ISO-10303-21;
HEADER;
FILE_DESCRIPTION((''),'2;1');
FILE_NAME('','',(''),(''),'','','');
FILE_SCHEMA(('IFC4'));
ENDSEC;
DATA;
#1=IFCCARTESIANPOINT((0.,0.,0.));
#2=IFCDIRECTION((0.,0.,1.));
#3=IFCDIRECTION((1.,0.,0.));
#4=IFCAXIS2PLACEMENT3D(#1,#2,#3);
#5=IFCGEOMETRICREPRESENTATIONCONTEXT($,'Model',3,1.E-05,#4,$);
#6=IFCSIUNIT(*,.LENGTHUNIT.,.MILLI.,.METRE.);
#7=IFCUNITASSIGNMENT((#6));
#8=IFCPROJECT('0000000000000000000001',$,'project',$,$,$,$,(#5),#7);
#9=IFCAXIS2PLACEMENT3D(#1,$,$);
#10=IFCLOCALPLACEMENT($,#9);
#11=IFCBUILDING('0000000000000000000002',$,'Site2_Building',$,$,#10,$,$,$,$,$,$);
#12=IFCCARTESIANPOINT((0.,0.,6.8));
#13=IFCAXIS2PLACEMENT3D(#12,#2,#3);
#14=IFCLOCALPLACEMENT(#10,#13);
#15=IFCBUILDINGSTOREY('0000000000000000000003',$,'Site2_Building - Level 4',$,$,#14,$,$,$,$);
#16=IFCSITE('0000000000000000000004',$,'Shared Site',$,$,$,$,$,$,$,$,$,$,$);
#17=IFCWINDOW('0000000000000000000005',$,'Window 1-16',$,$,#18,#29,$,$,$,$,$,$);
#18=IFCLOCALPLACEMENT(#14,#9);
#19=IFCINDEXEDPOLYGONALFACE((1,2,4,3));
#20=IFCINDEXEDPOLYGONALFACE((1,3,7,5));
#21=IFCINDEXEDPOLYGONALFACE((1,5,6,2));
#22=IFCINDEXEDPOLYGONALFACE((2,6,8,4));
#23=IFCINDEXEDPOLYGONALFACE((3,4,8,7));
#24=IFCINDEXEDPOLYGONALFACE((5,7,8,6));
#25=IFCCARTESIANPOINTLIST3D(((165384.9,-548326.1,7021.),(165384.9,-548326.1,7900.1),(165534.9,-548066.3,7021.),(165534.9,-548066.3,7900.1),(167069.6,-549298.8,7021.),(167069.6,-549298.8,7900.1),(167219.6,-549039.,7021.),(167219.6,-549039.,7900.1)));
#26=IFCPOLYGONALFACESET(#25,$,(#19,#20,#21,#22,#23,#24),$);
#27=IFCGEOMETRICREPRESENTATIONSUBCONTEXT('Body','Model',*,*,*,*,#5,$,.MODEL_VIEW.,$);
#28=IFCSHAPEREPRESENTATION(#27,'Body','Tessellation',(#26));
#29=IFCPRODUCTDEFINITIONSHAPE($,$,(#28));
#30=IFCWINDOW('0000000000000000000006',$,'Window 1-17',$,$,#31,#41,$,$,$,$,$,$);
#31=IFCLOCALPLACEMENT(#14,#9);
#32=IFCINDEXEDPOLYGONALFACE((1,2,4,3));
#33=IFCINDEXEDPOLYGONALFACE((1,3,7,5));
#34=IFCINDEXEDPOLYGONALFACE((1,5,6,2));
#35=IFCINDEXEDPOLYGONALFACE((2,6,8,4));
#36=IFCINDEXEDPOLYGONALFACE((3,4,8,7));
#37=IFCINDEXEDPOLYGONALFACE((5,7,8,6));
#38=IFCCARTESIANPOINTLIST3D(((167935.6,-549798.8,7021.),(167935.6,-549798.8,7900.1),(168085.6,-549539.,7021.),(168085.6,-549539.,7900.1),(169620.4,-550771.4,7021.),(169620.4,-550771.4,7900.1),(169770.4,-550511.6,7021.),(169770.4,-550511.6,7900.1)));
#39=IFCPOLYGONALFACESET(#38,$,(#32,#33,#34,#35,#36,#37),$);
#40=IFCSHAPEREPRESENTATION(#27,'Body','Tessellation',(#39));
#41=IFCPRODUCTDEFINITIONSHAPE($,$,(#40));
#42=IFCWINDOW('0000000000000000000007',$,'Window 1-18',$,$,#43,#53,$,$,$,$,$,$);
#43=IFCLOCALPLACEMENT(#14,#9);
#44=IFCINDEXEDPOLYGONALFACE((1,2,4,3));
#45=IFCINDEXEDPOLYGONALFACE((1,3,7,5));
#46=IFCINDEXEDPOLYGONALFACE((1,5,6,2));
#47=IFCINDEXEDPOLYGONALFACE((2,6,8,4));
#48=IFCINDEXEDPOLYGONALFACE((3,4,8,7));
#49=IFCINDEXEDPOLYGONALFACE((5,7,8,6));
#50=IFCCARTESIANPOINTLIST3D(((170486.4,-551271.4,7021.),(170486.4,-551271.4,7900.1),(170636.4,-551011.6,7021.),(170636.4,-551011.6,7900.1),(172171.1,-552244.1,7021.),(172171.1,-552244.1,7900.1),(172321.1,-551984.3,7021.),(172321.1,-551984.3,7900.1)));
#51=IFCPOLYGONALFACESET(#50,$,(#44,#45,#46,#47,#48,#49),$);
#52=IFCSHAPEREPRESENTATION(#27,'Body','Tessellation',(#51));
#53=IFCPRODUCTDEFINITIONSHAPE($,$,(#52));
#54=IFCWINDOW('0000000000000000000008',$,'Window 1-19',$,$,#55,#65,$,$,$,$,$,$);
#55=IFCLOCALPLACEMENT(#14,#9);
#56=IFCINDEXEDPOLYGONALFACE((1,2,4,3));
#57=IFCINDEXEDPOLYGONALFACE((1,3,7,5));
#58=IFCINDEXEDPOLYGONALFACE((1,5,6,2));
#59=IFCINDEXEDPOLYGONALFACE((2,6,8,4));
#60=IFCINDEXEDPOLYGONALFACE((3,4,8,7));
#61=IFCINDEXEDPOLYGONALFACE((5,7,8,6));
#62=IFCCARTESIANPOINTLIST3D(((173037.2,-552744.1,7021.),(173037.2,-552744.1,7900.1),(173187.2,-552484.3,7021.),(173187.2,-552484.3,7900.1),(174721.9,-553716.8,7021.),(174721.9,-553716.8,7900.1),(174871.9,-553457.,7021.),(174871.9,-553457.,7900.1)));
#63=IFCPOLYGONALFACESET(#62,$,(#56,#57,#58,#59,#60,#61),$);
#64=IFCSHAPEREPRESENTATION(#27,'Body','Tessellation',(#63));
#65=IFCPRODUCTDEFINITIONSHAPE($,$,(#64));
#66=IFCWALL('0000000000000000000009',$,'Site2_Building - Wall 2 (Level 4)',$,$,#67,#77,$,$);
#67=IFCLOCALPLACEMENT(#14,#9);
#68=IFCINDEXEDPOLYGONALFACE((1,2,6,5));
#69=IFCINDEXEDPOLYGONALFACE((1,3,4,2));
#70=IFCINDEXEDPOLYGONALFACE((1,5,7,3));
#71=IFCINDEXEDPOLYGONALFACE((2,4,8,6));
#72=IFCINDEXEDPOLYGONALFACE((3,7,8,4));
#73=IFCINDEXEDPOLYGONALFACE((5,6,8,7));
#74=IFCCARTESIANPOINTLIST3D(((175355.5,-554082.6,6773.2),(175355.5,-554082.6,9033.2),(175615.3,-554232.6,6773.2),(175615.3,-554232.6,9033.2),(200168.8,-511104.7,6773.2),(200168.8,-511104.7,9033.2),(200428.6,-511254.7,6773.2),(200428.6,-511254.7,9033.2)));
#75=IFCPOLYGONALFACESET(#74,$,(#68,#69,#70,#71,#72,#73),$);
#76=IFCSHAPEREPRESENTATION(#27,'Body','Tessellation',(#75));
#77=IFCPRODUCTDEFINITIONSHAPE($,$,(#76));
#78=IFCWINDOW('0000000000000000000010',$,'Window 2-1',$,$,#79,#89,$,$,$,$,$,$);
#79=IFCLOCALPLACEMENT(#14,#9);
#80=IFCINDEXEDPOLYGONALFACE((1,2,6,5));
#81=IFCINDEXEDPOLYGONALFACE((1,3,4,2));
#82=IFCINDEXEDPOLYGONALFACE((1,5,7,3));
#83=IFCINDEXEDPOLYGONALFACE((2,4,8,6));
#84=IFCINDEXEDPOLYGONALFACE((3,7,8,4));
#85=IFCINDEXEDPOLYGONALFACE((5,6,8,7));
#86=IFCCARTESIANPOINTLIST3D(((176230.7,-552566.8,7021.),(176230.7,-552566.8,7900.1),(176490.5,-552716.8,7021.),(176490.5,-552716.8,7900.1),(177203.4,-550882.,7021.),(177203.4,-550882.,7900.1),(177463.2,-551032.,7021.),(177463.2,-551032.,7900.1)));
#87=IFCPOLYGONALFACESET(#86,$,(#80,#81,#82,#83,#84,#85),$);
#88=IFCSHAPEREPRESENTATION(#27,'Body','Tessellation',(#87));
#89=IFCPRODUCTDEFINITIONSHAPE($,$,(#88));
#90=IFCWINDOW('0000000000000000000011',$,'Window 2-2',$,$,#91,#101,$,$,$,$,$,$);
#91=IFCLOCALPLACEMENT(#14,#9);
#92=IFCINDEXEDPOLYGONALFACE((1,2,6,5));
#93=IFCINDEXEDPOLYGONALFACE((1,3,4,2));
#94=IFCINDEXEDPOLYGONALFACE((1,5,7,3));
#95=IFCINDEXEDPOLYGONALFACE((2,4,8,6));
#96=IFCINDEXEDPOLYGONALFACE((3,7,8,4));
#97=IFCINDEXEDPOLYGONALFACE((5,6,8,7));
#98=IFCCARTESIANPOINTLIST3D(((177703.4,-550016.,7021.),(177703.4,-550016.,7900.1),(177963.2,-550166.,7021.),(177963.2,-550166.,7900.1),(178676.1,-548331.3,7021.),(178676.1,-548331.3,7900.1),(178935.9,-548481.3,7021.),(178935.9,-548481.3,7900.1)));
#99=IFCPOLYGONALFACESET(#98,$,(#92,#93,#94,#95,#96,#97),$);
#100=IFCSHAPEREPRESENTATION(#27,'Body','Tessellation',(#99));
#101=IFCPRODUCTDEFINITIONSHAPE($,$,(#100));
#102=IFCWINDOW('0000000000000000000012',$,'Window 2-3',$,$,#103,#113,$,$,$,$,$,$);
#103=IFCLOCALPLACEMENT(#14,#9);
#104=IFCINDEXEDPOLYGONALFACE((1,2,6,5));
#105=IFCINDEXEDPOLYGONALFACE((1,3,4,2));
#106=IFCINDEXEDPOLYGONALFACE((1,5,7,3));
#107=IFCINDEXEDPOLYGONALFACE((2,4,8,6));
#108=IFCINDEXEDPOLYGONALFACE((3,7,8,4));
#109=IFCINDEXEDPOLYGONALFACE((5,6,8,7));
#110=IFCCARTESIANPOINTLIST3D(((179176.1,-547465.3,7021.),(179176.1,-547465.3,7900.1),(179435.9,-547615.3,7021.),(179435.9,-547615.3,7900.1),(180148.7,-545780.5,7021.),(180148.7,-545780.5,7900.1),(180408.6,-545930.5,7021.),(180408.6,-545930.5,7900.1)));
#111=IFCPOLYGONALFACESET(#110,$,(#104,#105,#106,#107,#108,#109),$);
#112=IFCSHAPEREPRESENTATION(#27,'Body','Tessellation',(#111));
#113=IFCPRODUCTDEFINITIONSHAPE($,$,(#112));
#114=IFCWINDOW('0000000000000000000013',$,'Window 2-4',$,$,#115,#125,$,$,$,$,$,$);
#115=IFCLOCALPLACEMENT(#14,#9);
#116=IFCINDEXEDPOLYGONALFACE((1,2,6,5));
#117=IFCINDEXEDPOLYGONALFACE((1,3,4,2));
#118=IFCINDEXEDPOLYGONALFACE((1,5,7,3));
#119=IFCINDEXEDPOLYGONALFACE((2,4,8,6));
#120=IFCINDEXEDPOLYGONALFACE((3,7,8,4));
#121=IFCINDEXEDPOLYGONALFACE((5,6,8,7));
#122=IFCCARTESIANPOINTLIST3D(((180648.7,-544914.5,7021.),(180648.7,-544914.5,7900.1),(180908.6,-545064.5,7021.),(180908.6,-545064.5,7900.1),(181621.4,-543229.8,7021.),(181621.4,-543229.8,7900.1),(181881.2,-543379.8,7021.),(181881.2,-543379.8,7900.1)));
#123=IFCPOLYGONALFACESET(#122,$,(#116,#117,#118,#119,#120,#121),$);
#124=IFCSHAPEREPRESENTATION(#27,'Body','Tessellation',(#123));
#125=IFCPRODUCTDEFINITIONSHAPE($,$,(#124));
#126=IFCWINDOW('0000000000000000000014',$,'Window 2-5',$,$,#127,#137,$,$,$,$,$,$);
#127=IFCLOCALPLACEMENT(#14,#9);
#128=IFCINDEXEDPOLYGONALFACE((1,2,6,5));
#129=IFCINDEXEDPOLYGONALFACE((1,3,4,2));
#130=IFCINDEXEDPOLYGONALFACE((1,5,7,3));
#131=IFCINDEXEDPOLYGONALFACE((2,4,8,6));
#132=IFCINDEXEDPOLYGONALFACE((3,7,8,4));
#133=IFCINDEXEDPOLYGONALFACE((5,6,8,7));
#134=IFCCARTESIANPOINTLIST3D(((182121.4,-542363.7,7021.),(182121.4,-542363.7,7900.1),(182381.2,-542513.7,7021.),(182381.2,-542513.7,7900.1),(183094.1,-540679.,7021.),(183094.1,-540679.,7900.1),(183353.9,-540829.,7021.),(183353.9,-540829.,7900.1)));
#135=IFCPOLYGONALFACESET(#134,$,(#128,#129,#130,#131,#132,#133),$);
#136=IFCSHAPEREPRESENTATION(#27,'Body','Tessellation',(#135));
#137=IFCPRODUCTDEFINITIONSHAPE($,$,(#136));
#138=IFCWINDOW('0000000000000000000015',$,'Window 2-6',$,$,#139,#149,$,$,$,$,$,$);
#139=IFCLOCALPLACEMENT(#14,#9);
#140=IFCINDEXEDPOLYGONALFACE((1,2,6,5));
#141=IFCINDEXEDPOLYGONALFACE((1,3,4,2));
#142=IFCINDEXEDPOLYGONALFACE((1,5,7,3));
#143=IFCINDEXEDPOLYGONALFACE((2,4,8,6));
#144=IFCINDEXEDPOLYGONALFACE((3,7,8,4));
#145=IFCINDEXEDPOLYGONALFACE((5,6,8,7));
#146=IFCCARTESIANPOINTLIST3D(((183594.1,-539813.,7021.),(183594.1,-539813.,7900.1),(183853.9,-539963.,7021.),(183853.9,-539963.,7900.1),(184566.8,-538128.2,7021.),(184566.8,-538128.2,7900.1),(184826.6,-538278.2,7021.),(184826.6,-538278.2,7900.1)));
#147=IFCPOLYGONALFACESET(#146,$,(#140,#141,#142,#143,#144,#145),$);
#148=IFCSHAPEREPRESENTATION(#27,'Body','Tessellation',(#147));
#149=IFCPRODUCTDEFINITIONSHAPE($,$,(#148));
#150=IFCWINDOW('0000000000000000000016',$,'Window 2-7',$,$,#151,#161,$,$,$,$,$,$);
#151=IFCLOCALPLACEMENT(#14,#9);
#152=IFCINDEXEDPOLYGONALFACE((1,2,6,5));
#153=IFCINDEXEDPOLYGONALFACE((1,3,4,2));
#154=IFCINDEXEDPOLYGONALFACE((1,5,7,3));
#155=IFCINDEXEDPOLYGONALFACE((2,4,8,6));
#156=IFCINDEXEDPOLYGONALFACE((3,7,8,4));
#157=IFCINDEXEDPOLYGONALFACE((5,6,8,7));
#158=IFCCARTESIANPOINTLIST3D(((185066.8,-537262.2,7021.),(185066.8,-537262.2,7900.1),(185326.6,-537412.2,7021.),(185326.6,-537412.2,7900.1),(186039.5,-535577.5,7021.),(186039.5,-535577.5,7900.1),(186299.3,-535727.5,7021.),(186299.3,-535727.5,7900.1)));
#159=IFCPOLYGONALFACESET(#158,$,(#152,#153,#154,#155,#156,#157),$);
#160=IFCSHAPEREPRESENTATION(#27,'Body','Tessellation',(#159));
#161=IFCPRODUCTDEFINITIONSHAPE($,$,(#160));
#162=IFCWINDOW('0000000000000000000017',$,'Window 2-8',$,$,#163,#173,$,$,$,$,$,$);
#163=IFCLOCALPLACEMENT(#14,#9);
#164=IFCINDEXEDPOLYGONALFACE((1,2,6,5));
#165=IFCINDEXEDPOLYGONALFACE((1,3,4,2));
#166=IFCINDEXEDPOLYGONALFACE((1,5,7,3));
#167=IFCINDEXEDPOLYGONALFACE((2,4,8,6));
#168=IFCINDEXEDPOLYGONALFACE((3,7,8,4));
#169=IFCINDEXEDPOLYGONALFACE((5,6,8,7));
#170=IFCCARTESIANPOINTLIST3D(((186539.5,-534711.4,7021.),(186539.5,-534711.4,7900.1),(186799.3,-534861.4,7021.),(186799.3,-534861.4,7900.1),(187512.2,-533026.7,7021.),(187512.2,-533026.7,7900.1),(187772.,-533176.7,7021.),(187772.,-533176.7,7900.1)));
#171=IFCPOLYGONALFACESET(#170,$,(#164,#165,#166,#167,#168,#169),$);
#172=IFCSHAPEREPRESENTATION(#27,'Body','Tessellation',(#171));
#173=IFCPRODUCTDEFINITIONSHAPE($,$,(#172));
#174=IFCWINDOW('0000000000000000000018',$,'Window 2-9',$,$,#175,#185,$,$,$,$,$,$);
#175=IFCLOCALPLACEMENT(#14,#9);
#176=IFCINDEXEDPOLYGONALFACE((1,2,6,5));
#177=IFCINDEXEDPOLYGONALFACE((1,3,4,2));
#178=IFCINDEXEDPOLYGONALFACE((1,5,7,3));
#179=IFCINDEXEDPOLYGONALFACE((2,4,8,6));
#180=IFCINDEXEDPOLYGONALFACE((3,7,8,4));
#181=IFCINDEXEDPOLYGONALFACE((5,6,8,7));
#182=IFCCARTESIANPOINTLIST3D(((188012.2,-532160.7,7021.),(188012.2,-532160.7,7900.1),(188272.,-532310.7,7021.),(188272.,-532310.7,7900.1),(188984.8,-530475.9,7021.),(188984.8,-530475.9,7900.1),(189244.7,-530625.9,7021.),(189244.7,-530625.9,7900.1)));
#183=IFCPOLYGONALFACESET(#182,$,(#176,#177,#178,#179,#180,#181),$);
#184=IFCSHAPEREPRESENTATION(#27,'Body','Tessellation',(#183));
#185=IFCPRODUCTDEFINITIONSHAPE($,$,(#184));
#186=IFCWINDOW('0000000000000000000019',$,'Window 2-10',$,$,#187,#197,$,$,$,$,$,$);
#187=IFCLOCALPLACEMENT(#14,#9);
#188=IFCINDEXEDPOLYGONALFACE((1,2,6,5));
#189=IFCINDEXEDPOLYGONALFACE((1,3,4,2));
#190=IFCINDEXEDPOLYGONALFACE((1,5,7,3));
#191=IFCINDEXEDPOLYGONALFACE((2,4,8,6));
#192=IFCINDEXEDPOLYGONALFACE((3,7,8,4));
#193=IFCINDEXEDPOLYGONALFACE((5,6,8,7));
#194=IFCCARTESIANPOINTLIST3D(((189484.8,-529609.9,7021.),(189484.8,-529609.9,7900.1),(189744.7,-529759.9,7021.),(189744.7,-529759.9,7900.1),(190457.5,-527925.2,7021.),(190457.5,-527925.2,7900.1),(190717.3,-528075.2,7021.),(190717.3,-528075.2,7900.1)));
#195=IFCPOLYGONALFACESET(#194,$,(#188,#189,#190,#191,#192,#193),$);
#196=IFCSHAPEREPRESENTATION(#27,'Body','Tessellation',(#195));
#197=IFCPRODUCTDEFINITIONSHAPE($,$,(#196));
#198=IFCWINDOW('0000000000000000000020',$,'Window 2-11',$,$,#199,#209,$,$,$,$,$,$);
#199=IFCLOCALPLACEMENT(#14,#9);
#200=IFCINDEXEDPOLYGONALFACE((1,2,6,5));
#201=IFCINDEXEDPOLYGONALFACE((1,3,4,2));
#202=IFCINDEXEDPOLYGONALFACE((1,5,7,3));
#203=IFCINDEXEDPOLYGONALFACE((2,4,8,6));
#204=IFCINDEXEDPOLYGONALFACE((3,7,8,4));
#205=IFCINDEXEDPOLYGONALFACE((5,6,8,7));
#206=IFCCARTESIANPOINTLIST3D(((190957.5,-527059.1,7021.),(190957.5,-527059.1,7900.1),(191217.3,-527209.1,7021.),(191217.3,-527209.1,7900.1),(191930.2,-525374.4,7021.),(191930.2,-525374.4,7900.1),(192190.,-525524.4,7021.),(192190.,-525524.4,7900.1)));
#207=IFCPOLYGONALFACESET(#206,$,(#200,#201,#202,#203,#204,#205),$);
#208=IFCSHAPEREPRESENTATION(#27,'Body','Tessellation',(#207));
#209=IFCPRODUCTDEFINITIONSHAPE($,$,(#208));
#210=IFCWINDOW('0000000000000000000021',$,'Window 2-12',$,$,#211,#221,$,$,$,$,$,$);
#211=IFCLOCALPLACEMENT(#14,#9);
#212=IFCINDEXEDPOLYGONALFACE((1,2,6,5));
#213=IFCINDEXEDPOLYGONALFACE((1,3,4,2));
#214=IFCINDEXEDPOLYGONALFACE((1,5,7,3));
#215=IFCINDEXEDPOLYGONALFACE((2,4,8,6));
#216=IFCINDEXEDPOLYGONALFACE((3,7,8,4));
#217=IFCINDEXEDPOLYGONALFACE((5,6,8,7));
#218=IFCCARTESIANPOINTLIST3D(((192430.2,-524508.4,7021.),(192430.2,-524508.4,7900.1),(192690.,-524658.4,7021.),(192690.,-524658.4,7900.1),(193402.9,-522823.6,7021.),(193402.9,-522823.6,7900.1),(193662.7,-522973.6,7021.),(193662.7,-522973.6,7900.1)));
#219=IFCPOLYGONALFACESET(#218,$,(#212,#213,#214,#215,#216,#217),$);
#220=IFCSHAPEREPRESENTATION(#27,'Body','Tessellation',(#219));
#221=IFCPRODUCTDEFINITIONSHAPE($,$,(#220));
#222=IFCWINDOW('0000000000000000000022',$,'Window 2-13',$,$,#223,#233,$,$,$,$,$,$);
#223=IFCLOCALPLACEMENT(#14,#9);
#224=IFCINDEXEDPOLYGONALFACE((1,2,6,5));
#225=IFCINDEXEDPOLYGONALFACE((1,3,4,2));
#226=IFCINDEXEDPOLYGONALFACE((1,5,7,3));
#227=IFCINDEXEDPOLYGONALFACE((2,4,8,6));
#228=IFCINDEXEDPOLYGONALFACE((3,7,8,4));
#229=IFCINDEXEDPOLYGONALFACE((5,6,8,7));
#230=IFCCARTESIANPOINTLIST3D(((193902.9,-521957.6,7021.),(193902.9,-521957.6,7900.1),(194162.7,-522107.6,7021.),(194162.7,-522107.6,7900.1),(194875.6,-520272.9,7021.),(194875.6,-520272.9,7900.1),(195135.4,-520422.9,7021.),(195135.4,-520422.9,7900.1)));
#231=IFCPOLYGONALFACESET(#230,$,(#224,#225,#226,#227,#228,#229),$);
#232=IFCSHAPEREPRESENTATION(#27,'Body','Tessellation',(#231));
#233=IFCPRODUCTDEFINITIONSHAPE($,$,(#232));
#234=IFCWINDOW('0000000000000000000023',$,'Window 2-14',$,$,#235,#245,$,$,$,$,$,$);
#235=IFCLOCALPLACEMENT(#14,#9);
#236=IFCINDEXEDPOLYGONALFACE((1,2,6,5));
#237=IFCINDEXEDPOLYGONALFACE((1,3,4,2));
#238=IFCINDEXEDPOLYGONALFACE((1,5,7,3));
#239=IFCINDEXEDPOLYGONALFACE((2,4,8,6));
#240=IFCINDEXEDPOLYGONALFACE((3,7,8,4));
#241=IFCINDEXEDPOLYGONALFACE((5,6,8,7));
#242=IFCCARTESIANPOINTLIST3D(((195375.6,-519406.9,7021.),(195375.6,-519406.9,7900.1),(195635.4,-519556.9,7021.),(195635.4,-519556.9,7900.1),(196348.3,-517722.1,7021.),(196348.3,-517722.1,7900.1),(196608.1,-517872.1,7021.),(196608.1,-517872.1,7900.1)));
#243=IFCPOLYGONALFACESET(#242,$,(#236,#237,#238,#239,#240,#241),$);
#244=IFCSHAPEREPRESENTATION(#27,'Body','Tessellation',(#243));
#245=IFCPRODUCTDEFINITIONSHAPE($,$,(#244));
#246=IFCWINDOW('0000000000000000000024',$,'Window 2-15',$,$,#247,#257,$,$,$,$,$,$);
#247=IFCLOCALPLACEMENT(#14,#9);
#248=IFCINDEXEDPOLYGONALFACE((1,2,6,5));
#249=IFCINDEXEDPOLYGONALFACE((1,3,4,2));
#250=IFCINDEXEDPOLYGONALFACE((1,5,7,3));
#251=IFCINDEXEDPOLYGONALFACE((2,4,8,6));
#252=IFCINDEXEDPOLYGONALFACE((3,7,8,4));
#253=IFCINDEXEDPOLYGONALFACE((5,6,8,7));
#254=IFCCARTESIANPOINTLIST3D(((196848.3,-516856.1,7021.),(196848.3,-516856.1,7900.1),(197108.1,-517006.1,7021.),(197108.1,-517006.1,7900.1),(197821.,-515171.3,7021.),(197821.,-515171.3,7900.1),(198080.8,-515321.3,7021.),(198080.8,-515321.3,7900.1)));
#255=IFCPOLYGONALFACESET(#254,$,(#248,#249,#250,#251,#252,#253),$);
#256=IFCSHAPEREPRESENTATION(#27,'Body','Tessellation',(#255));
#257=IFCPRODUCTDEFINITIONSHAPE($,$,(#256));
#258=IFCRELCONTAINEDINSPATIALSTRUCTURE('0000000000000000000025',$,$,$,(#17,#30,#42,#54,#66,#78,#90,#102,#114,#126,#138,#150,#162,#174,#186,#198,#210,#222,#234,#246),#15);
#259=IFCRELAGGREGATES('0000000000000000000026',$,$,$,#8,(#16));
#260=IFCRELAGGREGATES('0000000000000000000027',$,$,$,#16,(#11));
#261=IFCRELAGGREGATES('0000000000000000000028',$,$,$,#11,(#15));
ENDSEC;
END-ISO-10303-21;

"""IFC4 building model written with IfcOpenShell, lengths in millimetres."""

from ifc_helpers import new_model, si_unit, frame, origin, origin_with_axes, place, context, subcontext, project, spatial, indexed_curve, outline, extrude, element, save


model = new_model("IFC4")

# Units and contexts
model_context = context("Model", 3, precision=1e-05, world=origin_with_axes())
body_context = subcontext(model_context, "Body", "Model", "MODEL_VIEW")
ifc_project = project(units=[si_unit("LENGTHUNIT", "METRE", prefix="MILLI")], contexts=[model_context])

# Site, building, storey
site = spatial("IfcSite", under=ifc_project, Name="Shared Site")
building_placement = place(None, origin())
building = spatial("IfcBuilding", under=site, at=building_placement, Name="Site2_Building")
storey_placement = place(building_placement, frame((0.0, 0.0, 6.8), z_axis=(0.0, 0.0, 1.0), x_axis=(1.0, 0.0, 0.0)))
storey = spatial("IfcBuildingStorey", under=building, at=storey_placement, Name="Site2_Building - Level 4")

# Windows
for number, where, z_axis, x_axis, name in (
    (1, (165384.9, -548326.1, 7021.0), (0.0, 0.0, 1.0), (0.866025, -0.5, 0.0), "Window 1-16"),
    (2, (167935.6, -549798.8, 7021.0), (0.0, 0.0, 1.0), (0.866025, -0.5, 0.0), "Window 1-17"),
    (3, (170486.4, -551271.4, 7021.0), (0.0, 0.0, 1.0), (0.866025, -0.5, 0.0), "Window 1-18"),
    (4, (173037.2, -552744.1, 7021.0), (0.0, 0.0, 1.0), (0.866025, -0.5, 0.0), "Window 1-19"),
):
    element("IfcWindow", number, at=place(storey_placement, frame(where, z_axis=z_axis, x_axis=x_axis)), inside=storey, Name=name, context=body_context, shape_type="SweptSolid", body=[
        extrude(outline(indexed_curve([(0.0, 0.0), (0.0, 300.0), (1945.4, 300.0), (1945.4, 0.0), (0.0, 0.0)], self_intersect=False)), origin_with_axes(), (0.0, 0.0, 1.0), 879.1),
    ])

# Wall
wall_1_placement = place(storey_placement, frame((175615.3, -554232.6, 6773.2), z_axis=(0.0, 0.0, 1.0), x_axis=(0.5, 0.866025, 0.0)))
element("IfcWall", 5, at=wall_1_placement, inside=storey, Name="Site2_Building - Wall 2 (Level 4)", context=body_context, shape_type="SweptSolid", body=[
    extrude(outline(indexed_curve([(0.0, 0.0), (0.0, 300.0), (49626.6, 300.0), (49626.6, 0.0), (0.0, 0.0)], self_intersect=False)), origin_with_axes(), (0.0, 0.0, 1.0), 2260.0),
])

# Windows
for number, where, z_axis, x_axis, name in (
    (6, (176490.5, -552716.8, 7021.0), (0.0, 0.0, 1.0), (0.5, 0.866025, 0.0), "Window 2-1"),
    (7, (177963.2, -550166.0, 7021.0), (0.0, 0.0, 1.0), (0.5, 0.866025, 0.0), "Window 2-2"),
    (8, (179435.9, -547615.3, 7021.0), (0.0, 0.0, 1.0), (0.5, 0.866025, 0.0), "Window 2-3"),
    (9, (180908.6, -545064.5, 7021.0), (0.0, 0.0, 1.0), (0.5, 0.866025, 0.0), "Window 2-4"),
    (10, (182381.2, -542513.7, 7021.0), (0.0, 0.0, 1.0), (0.5, 0.866025, 0.0), "Window 2-5"),
    (11, (183853.9, -539963.0, 7021.0), (0.0, 0.0, 1.0), (0.5, 0.866025, 0.0), "Window 2-6"),
    (12, (185326.6, -537412.2, 7021.0), (0.0, 0.0, 1.0), (0.5, 0.866025, 0.0), "Window 2-7"),
    (13, (186799.3, -534861.4, 7021.0), (0.0, 0.0, 1.0), (0.5, 0.866025, 0.0), "Window 2-8"),
    (14, (188272.0, -532310.7, 7021.0), (0.0, 0.0, 1.0), (0.5, 0.866025, 0.0), "Window 2-9"),
    (15, (189744.7, -529759.9, 7021.0), (0.0, 0.0, 1.0), (0.5, 0.866025, 0.0), "Window 2-10"),
    (16, (191217.3, -527209.1, 7021.0), (0.0, 0.0, 1.0), (0.5, 0.866025, 0.0), "Window 2-11"),
    (17, (192690.0, -524658.4, 7021.0), (0.0, 0.0, 1.0), (0.5, 0.866025, 0.0), "Window 2-12"),
    (18, (194162.7, -522107.6, 7021.0), (0.0, 0.0, 1.0), (0.5, 0.866025, 0.0), "Window 2-13"),
    (19, (195635.4, -519556.9, 7021.0), (0.0, 0.0, 1.0), (0.5, 0.866025, 0.0), "Window 2-14"),
    (20, (197108.1, -517006.1, 7021.0), (0.0, 0.0, 1.0), (0.5, 0.866025, 0.0), "Window 2-15"),
):
    element("IfcWindow", number, at=place(storey_placement, frame(where, z_axis=z_axis, x_axis=x_axis)), inside=storey, Name=name, context=body_context, shape_type="SweptSolid", body=[
        extrude(outline(indexed_curve([(0.0, 0.0), (0.0, 300.0), (1945.4, 300.0), (1945.4, 0.0), (0.0, 0.0)], self_intersect=False)), origin_with_axes(), (0.0, 0.0, 1.0), 879.1),
    ])

save(model, "model.ifc")
